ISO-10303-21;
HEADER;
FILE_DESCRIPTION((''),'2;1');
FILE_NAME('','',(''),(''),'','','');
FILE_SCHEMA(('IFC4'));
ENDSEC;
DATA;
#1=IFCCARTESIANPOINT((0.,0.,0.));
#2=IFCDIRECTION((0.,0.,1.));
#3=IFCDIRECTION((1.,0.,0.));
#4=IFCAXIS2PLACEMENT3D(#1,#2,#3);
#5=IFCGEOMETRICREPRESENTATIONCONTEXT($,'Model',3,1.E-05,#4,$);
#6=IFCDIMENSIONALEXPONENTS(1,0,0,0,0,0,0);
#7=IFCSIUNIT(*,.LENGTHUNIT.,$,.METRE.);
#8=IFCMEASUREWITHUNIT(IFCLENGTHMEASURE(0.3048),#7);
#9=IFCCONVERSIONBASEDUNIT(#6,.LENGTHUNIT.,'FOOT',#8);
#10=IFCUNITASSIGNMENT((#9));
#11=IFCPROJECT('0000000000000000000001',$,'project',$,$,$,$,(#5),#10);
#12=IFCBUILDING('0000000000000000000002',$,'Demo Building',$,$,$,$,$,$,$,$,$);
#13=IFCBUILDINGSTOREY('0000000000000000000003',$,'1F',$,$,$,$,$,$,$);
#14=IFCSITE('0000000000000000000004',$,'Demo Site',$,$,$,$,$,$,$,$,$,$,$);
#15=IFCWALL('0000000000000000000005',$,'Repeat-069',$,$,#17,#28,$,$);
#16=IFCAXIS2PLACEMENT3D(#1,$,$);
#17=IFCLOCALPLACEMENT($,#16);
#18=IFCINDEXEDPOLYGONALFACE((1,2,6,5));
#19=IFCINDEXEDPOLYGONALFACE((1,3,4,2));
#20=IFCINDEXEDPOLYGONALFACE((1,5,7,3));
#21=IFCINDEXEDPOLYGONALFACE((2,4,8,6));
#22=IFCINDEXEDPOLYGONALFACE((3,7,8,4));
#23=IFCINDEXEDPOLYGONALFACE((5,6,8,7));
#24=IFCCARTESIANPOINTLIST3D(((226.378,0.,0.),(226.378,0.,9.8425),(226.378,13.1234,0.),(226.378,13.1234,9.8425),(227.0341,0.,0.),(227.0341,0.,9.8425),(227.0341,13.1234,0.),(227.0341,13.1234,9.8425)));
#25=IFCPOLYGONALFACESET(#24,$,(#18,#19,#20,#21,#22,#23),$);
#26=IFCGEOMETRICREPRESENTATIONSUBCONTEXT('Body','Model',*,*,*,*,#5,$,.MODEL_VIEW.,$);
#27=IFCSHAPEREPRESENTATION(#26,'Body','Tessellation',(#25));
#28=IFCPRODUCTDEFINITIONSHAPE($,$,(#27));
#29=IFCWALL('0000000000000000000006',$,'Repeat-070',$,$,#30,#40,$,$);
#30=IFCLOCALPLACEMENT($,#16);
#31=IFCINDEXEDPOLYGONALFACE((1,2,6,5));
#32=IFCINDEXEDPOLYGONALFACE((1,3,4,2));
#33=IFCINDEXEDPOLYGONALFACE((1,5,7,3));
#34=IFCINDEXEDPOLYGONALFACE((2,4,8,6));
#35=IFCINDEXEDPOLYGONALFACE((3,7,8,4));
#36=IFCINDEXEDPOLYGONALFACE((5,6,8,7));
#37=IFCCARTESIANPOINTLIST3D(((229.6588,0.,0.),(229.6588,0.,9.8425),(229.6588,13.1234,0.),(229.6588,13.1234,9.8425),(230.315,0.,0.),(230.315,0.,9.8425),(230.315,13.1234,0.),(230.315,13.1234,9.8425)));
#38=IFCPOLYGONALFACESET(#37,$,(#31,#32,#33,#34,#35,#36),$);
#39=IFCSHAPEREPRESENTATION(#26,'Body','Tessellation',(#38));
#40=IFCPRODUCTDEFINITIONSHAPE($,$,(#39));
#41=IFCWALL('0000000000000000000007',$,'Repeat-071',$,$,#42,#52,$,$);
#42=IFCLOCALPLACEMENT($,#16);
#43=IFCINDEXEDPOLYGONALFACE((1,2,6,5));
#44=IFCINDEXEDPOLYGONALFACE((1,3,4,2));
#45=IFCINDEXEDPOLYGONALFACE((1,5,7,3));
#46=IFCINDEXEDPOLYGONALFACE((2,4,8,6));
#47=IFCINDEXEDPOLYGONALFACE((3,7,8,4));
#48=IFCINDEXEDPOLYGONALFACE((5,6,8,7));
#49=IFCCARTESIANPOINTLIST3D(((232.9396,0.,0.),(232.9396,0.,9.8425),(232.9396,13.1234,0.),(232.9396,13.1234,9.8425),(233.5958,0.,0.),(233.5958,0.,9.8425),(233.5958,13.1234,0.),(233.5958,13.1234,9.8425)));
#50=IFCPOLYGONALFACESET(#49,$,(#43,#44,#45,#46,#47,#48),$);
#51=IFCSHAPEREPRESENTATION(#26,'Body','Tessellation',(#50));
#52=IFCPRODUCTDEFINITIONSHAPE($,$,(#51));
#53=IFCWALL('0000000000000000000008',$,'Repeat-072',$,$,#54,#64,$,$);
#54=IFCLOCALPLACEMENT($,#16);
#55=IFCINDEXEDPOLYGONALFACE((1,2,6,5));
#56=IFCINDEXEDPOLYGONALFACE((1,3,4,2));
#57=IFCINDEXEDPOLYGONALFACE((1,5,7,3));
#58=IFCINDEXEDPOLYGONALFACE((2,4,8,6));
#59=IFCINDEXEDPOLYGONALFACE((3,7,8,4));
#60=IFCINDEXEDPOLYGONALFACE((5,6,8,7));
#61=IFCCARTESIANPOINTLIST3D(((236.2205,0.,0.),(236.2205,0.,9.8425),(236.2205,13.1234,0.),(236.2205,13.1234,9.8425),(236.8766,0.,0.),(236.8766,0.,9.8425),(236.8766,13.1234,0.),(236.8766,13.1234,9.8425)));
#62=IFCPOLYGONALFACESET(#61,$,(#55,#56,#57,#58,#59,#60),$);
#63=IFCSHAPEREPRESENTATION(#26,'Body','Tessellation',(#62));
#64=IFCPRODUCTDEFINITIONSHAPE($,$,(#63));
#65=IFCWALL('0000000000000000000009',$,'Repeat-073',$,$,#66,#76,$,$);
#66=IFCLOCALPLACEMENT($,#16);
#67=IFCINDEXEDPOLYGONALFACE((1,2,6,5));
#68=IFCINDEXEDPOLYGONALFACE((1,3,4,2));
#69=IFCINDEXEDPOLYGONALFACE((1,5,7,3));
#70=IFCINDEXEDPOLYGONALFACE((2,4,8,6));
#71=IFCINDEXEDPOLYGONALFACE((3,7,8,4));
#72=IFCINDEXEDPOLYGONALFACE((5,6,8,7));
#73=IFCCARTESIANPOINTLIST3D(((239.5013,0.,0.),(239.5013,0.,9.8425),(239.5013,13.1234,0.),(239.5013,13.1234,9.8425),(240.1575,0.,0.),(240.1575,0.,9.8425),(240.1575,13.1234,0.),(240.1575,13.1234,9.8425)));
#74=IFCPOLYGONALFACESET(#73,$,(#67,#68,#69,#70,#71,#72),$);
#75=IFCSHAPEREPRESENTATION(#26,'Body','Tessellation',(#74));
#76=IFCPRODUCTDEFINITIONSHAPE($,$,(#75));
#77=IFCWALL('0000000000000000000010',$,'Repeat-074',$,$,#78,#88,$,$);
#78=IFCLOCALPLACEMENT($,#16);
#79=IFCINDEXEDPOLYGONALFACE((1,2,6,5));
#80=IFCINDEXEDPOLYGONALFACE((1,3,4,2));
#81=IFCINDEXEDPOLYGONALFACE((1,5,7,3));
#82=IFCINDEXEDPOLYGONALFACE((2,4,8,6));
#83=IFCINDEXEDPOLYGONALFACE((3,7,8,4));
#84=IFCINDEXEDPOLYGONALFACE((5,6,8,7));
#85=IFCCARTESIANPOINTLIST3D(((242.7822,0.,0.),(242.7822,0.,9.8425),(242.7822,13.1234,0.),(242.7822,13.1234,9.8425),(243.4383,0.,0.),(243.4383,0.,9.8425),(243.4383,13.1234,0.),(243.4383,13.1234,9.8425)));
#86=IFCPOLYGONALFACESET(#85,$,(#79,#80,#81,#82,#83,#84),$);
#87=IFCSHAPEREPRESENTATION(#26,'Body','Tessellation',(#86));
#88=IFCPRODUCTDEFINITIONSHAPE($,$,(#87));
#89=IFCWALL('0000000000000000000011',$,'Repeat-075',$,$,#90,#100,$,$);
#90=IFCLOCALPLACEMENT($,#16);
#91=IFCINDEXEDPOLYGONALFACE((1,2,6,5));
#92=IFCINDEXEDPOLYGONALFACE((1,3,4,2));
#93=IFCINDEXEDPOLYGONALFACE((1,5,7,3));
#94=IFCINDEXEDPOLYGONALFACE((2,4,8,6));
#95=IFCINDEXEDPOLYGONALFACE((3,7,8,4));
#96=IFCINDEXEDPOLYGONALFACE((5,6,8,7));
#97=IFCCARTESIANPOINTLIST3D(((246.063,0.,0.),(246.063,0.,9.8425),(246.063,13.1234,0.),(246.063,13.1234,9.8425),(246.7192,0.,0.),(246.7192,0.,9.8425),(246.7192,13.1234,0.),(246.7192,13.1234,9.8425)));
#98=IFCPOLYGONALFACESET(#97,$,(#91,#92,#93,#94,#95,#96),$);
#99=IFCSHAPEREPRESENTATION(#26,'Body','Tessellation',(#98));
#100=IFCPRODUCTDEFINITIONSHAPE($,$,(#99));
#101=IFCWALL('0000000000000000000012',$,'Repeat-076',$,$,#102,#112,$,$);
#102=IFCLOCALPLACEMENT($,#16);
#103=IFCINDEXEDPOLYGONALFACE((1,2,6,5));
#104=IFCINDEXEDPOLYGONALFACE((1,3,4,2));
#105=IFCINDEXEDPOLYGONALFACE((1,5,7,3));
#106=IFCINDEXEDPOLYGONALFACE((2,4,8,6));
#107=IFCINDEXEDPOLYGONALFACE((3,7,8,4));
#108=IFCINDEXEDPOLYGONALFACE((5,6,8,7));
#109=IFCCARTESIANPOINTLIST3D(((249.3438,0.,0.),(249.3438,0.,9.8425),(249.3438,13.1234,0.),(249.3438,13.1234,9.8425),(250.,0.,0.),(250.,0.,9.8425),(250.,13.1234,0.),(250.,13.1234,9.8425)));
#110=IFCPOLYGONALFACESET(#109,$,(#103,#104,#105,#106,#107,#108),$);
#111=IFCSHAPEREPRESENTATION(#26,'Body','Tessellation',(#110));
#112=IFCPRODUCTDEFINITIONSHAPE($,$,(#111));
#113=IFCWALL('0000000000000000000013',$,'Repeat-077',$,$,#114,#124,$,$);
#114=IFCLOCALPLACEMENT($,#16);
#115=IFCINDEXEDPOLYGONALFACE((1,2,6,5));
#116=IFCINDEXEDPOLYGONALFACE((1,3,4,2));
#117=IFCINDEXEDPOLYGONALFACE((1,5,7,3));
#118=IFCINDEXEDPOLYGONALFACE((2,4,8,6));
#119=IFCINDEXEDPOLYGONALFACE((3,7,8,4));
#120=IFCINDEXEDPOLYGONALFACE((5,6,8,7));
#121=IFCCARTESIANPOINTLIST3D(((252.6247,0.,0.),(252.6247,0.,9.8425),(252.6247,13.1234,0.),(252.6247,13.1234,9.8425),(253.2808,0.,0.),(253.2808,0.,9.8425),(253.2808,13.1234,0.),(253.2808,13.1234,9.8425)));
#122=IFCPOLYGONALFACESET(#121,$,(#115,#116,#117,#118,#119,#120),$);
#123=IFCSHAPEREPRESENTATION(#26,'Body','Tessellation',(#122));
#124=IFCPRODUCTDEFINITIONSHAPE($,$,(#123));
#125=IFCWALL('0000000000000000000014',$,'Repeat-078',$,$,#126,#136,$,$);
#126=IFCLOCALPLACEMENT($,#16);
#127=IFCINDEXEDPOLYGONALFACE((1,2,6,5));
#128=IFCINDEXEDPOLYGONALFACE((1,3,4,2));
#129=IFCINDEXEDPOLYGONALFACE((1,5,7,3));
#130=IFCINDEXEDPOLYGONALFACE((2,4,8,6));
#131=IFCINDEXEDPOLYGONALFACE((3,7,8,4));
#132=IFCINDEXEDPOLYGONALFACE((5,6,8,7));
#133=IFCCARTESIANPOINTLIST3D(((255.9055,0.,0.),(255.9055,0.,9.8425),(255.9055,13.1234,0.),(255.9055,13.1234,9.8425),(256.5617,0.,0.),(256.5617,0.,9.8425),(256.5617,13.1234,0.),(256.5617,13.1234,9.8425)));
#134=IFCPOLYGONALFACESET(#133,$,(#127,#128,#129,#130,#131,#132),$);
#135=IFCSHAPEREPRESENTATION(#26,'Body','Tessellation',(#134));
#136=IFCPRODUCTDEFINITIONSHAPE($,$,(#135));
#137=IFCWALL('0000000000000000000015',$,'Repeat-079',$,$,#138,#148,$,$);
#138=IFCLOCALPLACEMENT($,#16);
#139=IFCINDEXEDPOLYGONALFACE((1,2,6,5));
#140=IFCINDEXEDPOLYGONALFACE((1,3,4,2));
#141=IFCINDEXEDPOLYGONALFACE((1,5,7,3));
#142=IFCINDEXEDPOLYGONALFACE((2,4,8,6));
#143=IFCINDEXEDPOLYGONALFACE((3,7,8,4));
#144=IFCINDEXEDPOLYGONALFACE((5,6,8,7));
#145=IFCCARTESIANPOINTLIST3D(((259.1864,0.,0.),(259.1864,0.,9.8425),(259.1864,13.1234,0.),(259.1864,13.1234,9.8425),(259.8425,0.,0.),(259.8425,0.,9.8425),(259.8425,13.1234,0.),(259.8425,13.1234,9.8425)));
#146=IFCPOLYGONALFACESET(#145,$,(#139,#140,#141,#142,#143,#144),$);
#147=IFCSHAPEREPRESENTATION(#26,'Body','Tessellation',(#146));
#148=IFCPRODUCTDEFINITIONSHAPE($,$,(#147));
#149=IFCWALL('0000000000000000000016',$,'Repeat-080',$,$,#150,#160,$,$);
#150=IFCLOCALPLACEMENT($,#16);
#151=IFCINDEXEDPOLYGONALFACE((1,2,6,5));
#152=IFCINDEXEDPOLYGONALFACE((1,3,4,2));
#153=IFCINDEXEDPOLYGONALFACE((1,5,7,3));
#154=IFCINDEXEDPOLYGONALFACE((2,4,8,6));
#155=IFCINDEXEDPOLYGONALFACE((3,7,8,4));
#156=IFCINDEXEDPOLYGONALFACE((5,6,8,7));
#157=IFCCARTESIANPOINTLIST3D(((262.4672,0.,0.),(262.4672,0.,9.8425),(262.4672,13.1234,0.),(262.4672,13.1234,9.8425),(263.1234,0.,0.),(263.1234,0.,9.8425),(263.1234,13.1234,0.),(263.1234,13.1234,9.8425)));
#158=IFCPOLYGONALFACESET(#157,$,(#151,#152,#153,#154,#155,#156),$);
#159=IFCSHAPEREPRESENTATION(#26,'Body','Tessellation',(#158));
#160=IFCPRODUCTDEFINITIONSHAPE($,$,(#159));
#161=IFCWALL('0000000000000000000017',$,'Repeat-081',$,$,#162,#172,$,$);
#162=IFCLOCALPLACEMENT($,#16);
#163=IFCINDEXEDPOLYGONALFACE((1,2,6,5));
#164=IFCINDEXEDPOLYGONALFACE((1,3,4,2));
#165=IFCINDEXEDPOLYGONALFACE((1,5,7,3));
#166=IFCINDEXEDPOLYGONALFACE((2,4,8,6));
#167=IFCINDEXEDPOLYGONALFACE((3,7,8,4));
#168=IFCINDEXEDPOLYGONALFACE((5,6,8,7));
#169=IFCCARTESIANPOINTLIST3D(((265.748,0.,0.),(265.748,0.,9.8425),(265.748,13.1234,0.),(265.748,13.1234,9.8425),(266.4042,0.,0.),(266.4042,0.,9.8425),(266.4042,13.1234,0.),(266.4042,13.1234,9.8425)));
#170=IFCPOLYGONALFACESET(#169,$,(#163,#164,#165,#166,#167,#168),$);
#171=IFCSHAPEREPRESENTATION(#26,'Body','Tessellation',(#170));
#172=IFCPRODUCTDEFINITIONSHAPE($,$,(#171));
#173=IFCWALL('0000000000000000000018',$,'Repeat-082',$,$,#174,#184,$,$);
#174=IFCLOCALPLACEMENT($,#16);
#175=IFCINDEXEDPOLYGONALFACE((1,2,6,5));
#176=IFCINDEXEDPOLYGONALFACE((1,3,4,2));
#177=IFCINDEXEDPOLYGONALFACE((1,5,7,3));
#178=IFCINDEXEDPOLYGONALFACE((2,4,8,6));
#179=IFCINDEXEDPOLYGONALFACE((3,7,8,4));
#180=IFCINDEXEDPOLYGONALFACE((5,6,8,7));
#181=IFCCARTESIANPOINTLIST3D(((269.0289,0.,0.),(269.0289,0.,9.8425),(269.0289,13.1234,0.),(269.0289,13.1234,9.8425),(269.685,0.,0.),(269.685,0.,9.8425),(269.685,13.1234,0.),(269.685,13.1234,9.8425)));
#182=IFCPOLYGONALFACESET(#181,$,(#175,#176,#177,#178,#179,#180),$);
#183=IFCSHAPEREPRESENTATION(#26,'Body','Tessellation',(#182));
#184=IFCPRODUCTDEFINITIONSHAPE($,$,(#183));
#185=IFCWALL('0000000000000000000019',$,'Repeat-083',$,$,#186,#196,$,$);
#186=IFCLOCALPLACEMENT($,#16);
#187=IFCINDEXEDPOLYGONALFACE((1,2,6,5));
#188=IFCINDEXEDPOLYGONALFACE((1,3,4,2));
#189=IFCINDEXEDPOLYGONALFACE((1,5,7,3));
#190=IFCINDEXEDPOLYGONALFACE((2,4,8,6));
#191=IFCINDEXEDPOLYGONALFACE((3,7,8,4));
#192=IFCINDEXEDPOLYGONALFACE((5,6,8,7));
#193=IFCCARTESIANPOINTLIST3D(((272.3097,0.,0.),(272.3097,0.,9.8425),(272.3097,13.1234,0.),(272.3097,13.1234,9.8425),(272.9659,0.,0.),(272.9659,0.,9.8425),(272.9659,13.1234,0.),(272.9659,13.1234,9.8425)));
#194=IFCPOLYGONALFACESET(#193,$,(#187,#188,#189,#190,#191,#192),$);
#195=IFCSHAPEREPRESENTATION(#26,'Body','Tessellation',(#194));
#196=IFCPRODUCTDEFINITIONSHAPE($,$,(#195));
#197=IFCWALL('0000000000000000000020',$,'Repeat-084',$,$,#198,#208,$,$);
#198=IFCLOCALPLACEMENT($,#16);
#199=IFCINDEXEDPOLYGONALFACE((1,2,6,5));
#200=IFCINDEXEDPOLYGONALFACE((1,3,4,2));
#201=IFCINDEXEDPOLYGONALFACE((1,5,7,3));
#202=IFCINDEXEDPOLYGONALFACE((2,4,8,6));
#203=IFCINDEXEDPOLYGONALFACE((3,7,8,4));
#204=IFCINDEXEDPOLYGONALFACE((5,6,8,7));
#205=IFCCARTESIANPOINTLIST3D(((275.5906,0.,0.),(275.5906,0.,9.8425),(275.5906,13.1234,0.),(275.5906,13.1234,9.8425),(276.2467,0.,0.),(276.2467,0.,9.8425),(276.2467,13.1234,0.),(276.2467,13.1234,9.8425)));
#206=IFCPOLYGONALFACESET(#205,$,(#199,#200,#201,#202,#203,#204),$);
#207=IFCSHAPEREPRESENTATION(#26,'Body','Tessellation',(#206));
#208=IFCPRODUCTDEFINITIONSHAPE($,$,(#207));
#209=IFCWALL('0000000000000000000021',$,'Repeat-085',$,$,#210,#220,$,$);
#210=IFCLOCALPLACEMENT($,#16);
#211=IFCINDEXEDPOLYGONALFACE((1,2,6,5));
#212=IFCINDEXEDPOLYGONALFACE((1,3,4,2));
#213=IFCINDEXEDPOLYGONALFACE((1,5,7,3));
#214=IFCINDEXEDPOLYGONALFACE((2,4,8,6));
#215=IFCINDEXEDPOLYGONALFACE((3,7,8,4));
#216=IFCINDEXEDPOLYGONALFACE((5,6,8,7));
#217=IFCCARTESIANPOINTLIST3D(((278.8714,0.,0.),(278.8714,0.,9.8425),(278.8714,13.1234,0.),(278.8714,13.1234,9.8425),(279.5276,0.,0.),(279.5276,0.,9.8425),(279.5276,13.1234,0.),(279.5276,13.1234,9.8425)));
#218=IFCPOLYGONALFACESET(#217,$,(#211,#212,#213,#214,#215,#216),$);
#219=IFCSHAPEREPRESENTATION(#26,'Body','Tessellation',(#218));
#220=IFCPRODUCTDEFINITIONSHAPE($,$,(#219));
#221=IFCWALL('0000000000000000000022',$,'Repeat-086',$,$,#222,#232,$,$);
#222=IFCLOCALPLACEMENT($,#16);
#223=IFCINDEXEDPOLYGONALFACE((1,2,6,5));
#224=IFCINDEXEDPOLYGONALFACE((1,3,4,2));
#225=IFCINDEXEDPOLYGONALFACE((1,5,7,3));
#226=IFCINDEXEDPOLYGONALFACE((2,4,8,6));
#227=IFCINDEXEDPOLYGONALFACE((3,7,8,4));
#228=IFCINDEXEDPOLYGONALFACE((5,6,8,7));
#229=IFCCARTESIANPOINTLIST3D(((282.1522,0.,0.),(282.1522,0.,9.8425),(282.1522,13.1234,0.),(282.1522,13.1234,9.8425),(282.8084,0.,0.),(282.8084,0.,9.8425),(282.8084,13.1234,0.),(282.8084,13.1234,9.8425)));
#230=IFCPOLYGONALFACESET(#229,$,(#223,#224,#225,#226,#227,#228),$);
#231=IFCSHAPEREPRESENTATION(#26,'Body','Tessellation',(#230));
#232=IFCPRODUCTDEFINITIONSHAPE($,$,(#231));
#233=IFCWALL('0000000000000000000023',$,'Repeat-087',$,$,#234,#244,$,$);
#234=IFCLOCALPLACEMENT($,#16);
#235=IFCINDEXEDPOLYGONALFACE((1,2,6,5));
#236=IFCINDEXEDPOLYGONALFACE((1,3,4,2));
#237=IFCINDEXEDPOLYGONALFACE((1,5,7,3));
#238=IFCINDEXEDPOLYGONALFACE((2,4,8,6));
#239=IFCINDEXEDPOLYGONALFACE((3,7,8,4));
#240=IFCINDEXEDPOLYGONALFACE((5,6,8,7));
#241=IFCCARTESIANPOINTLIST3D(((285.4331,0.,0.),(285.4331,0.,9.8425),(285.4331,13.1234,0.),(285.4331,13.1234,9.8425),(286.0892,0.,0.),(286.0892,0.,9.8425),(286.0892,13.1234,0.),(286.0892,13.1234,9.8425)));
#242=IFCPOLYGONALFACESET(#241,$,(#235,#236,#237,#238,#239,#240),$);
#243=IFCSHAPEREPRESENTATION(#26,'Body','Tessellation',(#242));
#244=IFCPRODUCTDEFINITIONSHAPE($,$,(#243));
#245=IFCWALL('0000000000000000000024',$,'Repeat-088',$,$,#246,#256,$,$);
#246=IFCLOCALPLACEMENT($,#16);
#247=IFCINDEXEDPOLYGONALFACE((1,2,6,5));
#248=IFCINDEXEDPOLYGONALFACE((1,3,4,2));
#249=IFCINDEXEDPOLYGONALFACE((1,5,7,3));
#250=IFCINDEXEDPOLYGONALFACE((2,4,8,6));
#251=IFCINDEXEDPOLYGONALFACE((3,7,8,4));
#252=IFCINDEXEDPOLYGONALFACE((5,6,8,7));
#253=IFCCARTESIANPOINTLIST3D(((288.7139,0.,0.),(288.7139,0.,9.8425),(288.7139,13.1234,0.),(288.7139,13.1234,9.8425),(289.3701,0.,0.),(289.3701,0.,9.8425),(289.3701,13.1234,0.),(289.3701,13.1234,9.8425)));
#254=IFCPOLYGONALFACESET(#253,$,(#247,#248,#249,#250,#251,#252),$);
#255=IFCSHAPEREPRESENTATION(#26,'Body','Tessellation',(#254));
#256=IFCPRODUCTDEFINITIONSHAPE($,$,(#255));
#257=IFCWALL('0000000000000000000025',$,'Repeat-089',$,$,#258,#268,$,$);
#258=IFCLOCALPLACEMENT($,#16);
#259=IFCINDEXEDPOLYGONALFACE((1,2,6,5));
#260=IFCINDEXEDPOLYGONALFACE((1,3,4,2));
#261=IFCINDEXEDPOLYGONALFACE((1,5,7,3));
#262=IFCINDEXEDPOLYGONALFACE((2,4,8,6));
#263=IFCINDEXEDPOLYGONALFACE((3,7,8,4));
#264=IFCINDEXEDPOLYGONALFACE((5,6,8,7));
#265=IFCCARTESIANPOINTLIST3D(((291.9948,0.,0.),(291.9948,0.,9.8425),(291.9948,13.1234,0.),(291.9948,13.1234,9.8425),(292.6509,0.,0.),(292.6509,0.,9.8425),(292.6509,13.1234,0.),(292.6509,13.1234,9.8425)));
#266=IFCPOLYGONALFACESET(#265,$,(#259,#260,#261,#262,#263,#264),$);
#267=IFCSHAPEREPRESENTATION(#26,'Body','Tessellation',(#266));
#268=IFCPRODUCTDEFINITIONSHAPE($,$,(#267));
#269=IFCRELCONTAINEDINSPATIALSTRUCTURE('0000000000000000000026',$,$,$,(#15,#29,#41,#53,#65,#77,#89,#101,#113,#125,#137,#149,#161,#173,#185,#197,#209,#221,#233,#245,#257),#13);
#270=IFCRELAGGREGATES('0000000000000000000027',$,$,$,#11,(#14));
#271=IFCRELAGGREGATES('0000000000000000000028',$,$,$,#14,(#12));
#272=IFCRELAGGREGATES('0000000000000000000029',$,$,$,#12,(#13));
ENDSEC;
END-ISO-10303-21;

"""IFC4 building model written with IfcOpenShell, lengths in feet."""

from ifc_helpers import new_model, entity, si_unit, converted_unit, frame, origin_with_axes, place, context, subcontext, project, spatial, element, save


model = new_model("IFC4")

# Units and contexts
model_context = context("Model", 3, precision=1e-05, world=origin_with_axes())
body_context = subcontext(model_context, "Body", "Model", "MODEL_VIEW")
ifc_project = project(units=[converted_unit("LENGTHUNIT", "FOOT", entity("IfcLengthMeasure", 0.3048), si_unit("LENGTHUNIT", "METRE"), dimensions=[1, 0, 0, 0, 0, 0, 0])], contexts=[model_context])

# Site, building, storey
site = spatial("IfcSite", under=ifc_project, Name="Demo Site")
building = spatial("IfcBuilding", under=site, Name="Demo Building")
storey = spatial("IfcBuildingStorey", under=building, Name="1F")

# Walls
for number, where, z_axis, x_axis, name in (
    (1, (226.378, 0.0, 0.0), (0.0, 0.0, 1.0), (1.0, 0.0, 0.0), "Repeat-069"),
    (2, (229.6588, 0.0, 0.0), (0.0, 0.0, 1.0), (1.0, 0.0, 0.0), "Repeat-070"),
    (3, (232.9396, 0.0, 0.0), (0.0, 0.0, 1.0), (1.0, 0.0, 0.0), "Repeat-071"),
    (4, (236.2205, 0.0, 0.0), (0.0, 0.0, 1.0), (1.0, 0.0, 0.0), "Repeat-072"),
    (5, (239.5013, 0.0, 0.0), (0.0, 0.0, 1.0), (1.0, 0.0, 0.0), "Repeat-073"),
    (6, (242.7822, 0.0, 0.0), (0.0, 0.0, 1.0), (1.0, 0.0, 0.0), "Repeat-074"),
    (7, (246.063, 0.0, 0.0), (0.0, 0.0, 1.0), (1.0, 0.0, 0.0), "Repeat-075"),
    (8, (249.3438, 0.0, 0.0), (0.0, 0.0, 1.0), (1.0, 0.0, 0.0), "Repeat-076"),
    (9, (252.6247, 0.0, 0.0), (0.0, 0.0, 1.0), (1.0, 0.0, 0.0), "Repeat-077"),
    (10, (255.9055, 0.0, 0.0), (0.0, 0.0, 1.0), (1.0, 0.0, 0.0), "Repeat-078"),
    (11, (259.1864, 0.0, 0.0), (0.0, 0.0, 1.0), (1.0, 0.0, 0.0), "Repeat-079"),
    (12, (262.4672, 0.0, 0.0), (0.0, 0.0, 1.0), (1.0, 0.0, 0.0), "Repeat-080"),
    (13, (265.748, 0.0, 0.0), (0.0, 0.0, 1.0), (1.0, 0.0, 0.0), "Repeat-081"),
    (14, (269.0289, 0.0, 0.0), (0.0, 0.0, 1.0), (1.0, 0.0, 0.0), "Repeat-082"),
    (15, (272.3097, 0.0, 0.0), (0.0, 0.0, 1.0), (1.0, 0.0, 0.0), "Repeat-083"),
    (16, (275.5906, 0.0, 0.0), (0.0, 0.0, 1.0), (1.0, 0.0, 0.0), "Repeat-084"),
    (17, (278.8714, 0.0, 0.0), (0.0, 0.0, 1.0), (1.0, 0.0, 0.0), "Repeat-085"),
    (18, (282.1522, 0.0, 0.0), (0.0, 0.0, 1.0), (1.0, 0.0, 0.0), "Repeat-086"),
    (19, (285.4331, 0.0, 0.0), (0.0, 0.0, 1.0), (1.0, 0.0, 0.0), "Repeat-087"),
    (20, (288.7139, 0.0, 0.0), (0.0, 0.0, 1.0), (1.0, 0.0, 0.0), "Repeat-088"),
    (21, (291.9948, 0.0, 0.0), (0.0, 0.0, 1.0), (1.0, 0.0, 0.0), "Repeat-089"),
):
    element("IfcWall", number, at=place(None, frame(where, z_axis=z_axis, x_axis=x_axis)), inside=storey, Name=name, context=body_context, shape_type="CSG", body=[
        entity("IfcBlock", entity("IfcAxis2Placement3D", entity("IfcCartesianPoint", [0.0, 0.0, 0.0]), entity("IfcDirection", [0.0, 0.0, 1.0]), entity("IfcDirection", [1.0, 0.0, 0.0])), 0.6562, 13.1234, 9.8425),
    ])

save(model, "model.ifc")
